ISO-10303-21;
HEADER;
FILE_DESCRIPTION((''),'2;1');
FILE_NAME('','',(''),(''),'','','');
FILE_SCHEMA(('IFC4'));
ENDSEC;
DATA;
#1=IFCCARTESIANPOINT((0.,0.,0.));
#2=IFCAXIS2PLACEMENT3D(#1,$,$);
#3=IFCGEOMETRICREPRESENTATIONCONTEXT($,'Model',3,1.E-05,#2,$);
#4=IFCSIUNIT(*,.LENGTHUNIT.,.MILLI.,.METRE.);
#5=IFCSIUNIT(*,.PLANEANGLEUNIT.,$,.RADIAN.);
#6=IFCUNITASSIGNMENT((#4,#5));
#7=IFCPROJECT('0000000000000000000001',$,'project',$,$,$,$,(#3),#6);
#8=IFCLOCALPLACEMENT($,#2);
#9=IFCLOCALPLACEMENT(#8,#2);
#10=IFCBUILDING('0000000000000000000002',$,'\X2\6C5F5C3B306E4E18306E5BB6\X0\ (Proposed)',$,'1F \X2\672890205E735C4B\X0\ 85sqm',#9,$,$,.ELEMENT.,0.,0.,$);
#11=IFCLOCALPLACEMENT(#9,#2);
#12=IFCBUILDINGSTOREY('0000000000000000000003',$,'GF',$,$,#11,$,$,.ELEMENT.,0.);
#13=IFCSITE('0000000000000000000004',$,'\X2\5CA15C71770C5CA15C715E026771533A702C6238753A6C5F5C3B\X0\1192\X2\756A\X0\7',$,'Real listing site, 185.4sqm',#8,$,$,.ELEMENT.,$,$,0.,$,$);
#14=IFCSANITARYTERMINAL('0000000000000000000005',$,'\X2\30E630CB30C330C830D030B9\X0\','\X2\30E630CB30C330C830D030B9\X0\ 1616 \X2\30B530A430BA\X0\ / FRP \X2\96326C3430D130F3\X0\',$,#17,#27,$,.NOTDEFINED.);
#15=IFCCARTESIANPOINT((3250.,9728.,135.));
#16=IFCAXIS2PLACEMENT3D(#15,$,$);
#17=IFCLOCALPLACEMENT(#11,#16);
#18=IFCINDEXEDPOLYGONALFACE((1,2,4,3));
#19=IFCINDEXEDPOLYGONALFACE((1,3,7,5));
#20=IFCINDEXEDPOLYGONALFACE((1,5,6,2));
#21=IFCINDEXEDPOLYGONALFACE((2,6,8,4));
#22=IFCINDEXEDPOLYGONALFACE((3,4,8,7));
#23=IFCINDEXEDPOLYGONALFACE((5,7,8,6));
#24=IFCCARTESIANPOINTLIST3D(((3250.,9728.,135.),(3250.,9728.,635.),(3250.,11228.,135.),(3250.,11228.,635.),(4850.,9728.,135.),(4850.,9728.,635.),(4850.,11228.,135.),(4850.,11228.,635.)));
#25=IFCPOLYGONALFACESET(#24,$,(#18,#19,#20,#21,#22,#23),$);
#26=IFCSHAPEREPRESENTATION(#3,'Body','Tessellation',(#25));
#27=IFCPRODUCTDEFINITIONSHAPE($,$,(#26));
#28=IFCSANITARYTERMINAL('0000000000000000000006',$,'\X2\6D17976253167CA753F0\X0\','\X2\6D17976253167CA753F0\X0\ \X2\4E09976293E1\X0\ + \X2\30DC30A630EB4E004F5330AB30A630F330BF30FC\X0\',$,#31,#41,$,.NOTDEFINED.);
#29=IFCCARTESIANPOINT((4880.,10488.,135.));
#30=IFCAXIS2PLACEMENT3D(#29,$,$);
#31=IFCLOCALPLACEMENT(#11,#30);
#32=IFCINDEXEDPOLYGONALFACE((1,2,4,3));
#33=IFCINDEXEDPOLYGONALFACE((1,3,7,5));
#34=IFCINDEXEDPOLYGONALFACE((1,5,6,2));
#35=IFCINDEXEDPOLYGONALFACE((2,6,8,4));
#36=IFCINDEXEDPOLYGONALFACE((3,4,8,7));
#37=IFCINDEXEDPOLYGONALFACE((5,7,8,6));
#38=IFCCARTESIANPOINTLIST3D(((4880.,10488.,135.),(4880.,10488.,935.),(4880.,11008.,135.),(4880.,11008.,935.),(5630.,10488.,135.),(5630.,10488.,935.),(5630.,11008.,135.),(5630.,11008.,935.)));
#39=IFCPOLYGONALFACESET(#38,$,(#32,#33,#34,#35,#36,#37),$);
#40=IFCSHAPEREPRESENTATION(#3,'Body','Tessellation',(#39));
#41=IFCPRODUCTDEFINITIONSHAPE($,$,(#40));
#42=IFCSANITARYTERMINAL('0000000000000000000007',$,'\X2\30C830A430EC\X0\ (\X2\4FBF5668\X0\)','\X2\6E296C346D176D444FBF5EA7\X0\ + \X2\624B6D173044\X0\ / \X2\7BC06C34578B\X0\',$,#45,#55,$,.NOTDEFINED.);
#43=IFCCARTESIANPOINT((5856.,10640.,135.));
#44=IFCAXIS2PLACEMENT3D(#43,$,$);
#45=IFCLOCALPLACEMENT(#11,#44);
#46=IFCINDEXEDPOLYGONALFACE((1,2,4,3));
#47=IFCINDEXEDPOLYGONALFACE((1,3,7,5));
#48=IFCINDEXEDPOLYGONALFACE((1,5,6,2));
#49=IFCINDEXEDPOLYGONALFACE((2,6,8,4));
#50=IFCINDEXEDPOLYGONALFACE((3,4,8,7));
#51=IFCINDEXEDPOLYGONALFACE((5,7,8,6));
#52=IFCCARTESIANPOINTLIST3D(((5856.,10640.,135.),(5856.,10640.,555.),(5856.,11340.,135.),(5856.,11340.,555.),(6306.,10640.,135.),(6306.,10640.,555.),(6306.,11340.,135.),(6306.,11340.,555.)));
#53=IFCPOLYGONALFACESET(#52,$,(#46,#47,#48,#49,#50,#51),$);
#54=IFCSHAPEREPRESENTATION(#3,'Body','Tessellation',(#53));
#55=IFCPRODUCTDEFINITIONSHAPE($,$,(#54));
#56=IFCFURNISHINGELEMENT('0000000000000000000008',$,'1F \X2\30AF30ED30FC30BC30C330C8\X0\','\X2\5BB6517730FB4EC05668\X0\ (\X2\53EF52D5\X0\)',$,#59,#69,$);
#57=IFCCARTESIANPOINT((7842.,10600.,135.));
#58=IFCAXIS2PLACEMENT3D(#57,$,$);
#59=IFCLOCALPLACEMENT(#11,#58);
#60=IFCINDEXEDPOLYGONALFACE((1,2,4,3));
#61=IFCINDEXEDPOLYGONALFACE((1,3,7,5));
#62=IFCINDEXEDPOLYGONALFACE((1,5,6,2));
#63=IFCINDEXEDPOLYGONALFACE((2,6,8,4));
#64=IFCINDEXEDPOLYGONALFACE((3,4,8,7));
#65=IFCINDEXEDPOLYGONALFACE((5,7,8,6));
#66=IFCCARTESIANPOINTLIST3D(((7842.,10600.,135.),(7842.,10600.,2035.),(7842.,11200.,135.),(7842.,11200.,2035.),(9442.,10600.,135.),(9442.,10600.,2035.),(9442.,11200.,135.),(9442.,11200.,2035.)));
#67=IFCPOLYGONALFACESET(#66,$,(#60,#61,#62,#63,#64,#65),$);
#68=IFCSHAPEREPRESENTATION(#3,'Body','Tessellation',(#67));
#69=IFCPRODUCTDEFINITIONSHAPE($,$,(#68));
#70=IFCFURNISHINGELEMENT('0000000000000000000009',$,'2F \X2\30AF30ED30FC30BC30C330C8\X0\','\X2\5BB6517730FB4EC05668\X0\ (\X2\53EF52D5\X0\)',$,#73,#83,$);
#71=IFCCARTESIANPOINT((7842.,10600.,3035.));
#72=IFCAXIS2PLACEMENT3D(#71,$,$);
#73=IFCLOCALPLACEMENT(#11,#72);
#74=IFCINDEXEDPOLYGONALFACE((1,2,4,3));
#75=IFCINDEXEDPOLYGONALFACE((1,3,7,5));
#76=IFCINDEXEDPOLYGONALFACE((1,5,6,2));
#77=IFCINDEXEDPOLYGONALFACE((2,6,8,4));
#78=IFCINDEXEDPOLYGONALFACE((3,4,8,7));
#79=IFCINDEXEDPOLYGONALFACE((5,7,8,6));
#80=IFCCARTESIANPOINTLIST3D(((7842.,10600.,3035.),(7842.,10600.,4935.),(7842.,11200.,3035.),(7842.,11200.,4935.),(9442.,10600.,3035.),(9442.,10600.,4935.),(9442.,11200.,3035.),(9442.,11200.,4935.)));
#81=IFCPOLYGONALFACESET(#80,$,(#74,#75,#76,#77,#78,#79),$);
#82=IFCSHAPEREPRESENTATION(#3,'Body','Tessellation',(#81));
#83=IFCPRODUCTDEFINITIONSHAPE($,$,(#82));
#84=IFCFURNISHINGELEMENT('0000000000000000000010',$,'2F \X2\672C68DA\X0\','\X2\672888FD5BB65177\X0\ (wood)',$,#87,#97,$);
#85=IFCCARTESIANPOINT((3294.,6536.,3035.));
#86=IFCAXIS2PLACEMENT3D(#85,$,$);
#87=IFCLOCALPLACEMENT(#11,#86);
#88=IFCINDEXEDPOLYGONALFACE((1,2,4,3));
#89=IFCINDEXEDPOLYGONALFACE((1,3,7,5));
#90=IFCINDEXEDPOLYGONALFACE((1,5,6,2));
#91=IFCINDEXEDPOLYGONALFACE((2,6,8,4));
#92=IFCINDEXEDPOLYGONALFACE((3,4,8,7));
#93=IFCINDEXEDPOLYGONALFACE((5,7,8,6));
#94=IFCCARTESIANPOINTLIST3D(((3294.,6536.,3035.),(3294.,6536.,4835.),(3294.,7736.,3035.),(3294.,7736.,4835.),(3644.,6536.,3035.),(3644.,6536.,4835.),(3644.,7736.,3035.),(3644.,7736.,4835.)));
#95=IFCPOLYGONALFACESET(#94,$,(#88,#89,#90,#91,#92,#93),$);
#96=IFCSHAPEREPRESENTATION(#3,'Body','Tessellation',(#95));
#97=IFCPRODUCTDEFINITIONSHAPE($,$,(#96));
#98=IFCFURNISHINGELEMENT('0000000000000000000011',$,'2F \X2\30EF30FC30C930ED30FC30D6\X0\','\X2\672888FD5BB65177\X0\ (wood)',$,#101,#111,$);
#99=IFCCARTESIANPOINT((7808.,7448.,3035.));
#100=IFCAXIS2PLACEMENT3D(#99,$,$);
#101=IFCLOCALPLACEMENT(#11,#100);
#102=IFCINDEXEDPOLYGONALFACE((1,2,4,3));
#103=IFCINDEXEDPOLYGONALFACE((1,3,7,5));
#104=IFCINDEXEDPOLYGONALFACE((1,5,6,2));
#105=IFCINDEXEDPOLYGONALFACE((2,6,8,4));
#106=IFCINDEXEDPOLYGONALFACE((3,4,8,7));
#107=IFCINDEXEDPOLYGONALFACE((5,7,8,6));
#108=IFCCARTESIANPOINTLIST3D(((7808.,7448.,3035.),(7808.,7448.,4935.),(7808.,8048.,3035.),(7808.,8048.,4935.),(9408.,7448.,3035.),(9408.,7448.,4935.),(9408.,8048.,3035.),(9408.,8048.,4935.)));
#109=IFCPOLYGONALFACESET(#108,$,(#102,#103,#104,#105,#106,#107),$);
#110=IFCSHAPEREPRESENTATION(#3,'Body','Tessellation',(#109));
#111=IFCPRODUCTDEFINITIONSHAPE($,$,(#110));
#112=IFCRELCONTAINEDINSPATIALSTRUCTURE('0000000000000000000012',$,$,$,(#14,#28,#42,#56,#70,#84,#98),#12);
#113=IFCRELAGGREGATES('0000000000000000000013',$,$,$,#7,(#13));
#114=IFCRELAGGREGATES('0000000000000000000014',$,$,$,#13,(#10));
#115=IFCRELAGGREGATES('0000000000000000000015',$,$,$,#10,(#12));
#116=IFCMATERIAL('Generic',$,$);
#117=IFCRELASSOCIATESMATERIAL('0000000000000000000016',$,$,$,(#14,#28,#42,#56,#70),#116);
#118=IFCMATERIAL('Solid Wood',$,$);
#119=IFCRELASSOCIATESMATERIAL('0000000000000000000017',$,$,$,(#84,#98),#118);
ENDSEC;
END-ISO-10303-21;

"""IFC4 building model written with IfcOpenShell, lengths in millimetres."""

from ifc_helpers import new_model, si_unit, frame, frame_2d, origin, place, context, project, spatial, rectangle, extrude, material, element, save


model = new_model("IFC4")

# Units and contexts
model_context = context("Model", 3, precision=1e-05, world=origin())
ifc_project = project(units=[si_unit("LENGTHUNIT", "METRE", prefix="MILLI"), si_unit("PLANEANGLEUNIT", "RADIAN")], contexts=[model_context])

# Site, building, storey
site_placement = place(None, origin())
site = spatial("IfcSite", under=ifc_project, at=site_placement, Name="岡山県岡山市東区瀬戸町江尻1192番7", ObjectType="Real listing site, 185.4sqm", CompositionType="ELEMENT", RefElevation=0.0)
building_placement = place(site_placement, origin())
building = spatial("IfcBuilding", under=site, at=building_placement, Name="江尻の丘の家 (Proposed)", ObjectType="1F 木造平屋 85sqm", CompositionType="ELEMENT", ElevationOfRefHeight=0.0, ElevationOfTerrain=0.0)
storey_placement = place(building_placement, origin())
storey = spatial("IfcBuildingStorey", under=building, at=storey_placement, Name="GF", CompositionType="ELEMENT", Elevation=0.0)

# Shared definitions
ifc_material_1 = material(Name="Solid Wood")

# Shared definitions
ifc_material_2 = material(Name="Generic")

# Sanitary terminals
sanitary_terminal_1_placement = place(storey_placement, frame((3250.0, 9728.0, 135.0)))
element("IfcSanitaryTerminal", 1, at=sanitary_terminal_1_placement, inside=storey, material=ifc_material_2, Name="ユニットバス", Description="ユニットバス 1616 サイズ / FRP 防水パン", PredefinedType="NOTDEFINED", context=model_context, shape_type="SweptSolid", body=[
    extrude(rectangle(XDim=1600.0, YDim=1500.0, at=frame_2d((800.0, 750.0))), frame((3250.0, 9728.0, 135.0)), (0.0, 0.0, 1.0), 500.0),
])
sanitary_terminal_2_placement = place(storey_placement, frame((4880.0, 10488.0, 135.0)))
element("IfcSanitaryTerminal", 2, at=sanitary_terminal_2_placement, inside=storey, material=ifc_material_2, Name="洗面化粧台", Description="洗面化粧台 三面鏡 + ボウル一体カウンター", PredefinedType="NOTDEFINED", context=model_context, shape_type="SweptSolid", body=[
    extrude(rectangle(XDim=750.0, YDim=520.0, at=frame_2d((375.0, 260.0))), frame((4880.0, 10488.0, 135.0)), (0.0, 0.0, 1.0), 800.0),
])
sanitary_terminal_3_placement = place(storey_placement, frame((5856.0, 10640.0, 135.0)))
element("IfcSanitaryTerminal", 3, at=sanitary_terminal_3_placement, inside=storey, material=ifc_material_2, Name="トイレ (便器)", Description="温水洗浄便座 + 手洗い / 節水型", PredefinedType="NOTDEFINED", context=model_context, shape_type="SweptSolid", body=[
    extrude(rectangle(XDim=450.0, YDim=700.0, at=frame_2d((225.0, 350.0))), frame((5856.0, 10640.0, 135.0)), (0.0, 0.0, 1.0), 420.0),
])

# Furnishing elements
furnishing_1_placement = place(storey_placement, frame((7842.0, 10600.0, 135.0)))
element("IfcFurnishingElement", 4, at=furnishing_1_placement, inside=storey, material=ifc_material_2, Name="1F クローゼット", Description="家具・什器 (可動)", context=model_context, shape_type="SweptSolid", body=[
    extrude(rectangle(XDim=1600.0, YDim=600.0, at=frame_2d((800.0, 300.0))), frame((7842.0, 10600.0, 135.0)), (0.0, 0.0, 1.0), 1900.0),
])
furnishing_2_placement = place(storey_placement, frame((7842.0, 10600.0, 3035.0)))
element("IfcFurnishingElement", 5, at=furnishing_2_placement, inside=storey, material=ifc_material_2, Name="2F クローゼット", Description="家具・什器 (可動)", context=model_context, shape_type="SweptSolid", body=[
    extrude(rectangle(XDim=1600.0, YDim=600.0, at=frame_2d((800.0, 300.0))), frame((7842.0, 10600.0, 3035.0)), (0.0, 0.0, 1.0), 1900.0),
])
furnishing_3_placement = place(storey_placement, frame((3294.0, 6536.0, 3035.0)))
element("IfcFurnishingElement", 6, at=furnishing_3_placement, inside=storey, material=ifc_material_1, Name="2F 本棚", Description="木製家具 (wood)", context=model_context, shape_type="SweptSolid", body=[
    extrude(rectangle(XDim=350.0, YDim=1200.0, at=frame_2d((175.0, 600.0))), frame((3294.0, 6536.0, 3035.0)), (0.0, 0.0, 1.0), 1800.0),
])
furnishing_4_placement = place(storey_placement, frame((7808.0, 7448.0, 3035.0)))
element("IfcFurnishingElement", 7, at=furnishing_4_placement, inside=storey, material=ifc_material_1, Name="2F ワードローブ", Description="木製家具 (wood)", context=model_context, shape_type="SweptSolid", body=[
    extrude(rectangle(XDim=1600.0, YDim=600.0, at=frame_2d((800.0, 300.0))), frame((7808.0, 7448.0, 3035.0)), (0.0, 0.0, 1.0), 1900.0),
])

save(model, "model.ifc")
